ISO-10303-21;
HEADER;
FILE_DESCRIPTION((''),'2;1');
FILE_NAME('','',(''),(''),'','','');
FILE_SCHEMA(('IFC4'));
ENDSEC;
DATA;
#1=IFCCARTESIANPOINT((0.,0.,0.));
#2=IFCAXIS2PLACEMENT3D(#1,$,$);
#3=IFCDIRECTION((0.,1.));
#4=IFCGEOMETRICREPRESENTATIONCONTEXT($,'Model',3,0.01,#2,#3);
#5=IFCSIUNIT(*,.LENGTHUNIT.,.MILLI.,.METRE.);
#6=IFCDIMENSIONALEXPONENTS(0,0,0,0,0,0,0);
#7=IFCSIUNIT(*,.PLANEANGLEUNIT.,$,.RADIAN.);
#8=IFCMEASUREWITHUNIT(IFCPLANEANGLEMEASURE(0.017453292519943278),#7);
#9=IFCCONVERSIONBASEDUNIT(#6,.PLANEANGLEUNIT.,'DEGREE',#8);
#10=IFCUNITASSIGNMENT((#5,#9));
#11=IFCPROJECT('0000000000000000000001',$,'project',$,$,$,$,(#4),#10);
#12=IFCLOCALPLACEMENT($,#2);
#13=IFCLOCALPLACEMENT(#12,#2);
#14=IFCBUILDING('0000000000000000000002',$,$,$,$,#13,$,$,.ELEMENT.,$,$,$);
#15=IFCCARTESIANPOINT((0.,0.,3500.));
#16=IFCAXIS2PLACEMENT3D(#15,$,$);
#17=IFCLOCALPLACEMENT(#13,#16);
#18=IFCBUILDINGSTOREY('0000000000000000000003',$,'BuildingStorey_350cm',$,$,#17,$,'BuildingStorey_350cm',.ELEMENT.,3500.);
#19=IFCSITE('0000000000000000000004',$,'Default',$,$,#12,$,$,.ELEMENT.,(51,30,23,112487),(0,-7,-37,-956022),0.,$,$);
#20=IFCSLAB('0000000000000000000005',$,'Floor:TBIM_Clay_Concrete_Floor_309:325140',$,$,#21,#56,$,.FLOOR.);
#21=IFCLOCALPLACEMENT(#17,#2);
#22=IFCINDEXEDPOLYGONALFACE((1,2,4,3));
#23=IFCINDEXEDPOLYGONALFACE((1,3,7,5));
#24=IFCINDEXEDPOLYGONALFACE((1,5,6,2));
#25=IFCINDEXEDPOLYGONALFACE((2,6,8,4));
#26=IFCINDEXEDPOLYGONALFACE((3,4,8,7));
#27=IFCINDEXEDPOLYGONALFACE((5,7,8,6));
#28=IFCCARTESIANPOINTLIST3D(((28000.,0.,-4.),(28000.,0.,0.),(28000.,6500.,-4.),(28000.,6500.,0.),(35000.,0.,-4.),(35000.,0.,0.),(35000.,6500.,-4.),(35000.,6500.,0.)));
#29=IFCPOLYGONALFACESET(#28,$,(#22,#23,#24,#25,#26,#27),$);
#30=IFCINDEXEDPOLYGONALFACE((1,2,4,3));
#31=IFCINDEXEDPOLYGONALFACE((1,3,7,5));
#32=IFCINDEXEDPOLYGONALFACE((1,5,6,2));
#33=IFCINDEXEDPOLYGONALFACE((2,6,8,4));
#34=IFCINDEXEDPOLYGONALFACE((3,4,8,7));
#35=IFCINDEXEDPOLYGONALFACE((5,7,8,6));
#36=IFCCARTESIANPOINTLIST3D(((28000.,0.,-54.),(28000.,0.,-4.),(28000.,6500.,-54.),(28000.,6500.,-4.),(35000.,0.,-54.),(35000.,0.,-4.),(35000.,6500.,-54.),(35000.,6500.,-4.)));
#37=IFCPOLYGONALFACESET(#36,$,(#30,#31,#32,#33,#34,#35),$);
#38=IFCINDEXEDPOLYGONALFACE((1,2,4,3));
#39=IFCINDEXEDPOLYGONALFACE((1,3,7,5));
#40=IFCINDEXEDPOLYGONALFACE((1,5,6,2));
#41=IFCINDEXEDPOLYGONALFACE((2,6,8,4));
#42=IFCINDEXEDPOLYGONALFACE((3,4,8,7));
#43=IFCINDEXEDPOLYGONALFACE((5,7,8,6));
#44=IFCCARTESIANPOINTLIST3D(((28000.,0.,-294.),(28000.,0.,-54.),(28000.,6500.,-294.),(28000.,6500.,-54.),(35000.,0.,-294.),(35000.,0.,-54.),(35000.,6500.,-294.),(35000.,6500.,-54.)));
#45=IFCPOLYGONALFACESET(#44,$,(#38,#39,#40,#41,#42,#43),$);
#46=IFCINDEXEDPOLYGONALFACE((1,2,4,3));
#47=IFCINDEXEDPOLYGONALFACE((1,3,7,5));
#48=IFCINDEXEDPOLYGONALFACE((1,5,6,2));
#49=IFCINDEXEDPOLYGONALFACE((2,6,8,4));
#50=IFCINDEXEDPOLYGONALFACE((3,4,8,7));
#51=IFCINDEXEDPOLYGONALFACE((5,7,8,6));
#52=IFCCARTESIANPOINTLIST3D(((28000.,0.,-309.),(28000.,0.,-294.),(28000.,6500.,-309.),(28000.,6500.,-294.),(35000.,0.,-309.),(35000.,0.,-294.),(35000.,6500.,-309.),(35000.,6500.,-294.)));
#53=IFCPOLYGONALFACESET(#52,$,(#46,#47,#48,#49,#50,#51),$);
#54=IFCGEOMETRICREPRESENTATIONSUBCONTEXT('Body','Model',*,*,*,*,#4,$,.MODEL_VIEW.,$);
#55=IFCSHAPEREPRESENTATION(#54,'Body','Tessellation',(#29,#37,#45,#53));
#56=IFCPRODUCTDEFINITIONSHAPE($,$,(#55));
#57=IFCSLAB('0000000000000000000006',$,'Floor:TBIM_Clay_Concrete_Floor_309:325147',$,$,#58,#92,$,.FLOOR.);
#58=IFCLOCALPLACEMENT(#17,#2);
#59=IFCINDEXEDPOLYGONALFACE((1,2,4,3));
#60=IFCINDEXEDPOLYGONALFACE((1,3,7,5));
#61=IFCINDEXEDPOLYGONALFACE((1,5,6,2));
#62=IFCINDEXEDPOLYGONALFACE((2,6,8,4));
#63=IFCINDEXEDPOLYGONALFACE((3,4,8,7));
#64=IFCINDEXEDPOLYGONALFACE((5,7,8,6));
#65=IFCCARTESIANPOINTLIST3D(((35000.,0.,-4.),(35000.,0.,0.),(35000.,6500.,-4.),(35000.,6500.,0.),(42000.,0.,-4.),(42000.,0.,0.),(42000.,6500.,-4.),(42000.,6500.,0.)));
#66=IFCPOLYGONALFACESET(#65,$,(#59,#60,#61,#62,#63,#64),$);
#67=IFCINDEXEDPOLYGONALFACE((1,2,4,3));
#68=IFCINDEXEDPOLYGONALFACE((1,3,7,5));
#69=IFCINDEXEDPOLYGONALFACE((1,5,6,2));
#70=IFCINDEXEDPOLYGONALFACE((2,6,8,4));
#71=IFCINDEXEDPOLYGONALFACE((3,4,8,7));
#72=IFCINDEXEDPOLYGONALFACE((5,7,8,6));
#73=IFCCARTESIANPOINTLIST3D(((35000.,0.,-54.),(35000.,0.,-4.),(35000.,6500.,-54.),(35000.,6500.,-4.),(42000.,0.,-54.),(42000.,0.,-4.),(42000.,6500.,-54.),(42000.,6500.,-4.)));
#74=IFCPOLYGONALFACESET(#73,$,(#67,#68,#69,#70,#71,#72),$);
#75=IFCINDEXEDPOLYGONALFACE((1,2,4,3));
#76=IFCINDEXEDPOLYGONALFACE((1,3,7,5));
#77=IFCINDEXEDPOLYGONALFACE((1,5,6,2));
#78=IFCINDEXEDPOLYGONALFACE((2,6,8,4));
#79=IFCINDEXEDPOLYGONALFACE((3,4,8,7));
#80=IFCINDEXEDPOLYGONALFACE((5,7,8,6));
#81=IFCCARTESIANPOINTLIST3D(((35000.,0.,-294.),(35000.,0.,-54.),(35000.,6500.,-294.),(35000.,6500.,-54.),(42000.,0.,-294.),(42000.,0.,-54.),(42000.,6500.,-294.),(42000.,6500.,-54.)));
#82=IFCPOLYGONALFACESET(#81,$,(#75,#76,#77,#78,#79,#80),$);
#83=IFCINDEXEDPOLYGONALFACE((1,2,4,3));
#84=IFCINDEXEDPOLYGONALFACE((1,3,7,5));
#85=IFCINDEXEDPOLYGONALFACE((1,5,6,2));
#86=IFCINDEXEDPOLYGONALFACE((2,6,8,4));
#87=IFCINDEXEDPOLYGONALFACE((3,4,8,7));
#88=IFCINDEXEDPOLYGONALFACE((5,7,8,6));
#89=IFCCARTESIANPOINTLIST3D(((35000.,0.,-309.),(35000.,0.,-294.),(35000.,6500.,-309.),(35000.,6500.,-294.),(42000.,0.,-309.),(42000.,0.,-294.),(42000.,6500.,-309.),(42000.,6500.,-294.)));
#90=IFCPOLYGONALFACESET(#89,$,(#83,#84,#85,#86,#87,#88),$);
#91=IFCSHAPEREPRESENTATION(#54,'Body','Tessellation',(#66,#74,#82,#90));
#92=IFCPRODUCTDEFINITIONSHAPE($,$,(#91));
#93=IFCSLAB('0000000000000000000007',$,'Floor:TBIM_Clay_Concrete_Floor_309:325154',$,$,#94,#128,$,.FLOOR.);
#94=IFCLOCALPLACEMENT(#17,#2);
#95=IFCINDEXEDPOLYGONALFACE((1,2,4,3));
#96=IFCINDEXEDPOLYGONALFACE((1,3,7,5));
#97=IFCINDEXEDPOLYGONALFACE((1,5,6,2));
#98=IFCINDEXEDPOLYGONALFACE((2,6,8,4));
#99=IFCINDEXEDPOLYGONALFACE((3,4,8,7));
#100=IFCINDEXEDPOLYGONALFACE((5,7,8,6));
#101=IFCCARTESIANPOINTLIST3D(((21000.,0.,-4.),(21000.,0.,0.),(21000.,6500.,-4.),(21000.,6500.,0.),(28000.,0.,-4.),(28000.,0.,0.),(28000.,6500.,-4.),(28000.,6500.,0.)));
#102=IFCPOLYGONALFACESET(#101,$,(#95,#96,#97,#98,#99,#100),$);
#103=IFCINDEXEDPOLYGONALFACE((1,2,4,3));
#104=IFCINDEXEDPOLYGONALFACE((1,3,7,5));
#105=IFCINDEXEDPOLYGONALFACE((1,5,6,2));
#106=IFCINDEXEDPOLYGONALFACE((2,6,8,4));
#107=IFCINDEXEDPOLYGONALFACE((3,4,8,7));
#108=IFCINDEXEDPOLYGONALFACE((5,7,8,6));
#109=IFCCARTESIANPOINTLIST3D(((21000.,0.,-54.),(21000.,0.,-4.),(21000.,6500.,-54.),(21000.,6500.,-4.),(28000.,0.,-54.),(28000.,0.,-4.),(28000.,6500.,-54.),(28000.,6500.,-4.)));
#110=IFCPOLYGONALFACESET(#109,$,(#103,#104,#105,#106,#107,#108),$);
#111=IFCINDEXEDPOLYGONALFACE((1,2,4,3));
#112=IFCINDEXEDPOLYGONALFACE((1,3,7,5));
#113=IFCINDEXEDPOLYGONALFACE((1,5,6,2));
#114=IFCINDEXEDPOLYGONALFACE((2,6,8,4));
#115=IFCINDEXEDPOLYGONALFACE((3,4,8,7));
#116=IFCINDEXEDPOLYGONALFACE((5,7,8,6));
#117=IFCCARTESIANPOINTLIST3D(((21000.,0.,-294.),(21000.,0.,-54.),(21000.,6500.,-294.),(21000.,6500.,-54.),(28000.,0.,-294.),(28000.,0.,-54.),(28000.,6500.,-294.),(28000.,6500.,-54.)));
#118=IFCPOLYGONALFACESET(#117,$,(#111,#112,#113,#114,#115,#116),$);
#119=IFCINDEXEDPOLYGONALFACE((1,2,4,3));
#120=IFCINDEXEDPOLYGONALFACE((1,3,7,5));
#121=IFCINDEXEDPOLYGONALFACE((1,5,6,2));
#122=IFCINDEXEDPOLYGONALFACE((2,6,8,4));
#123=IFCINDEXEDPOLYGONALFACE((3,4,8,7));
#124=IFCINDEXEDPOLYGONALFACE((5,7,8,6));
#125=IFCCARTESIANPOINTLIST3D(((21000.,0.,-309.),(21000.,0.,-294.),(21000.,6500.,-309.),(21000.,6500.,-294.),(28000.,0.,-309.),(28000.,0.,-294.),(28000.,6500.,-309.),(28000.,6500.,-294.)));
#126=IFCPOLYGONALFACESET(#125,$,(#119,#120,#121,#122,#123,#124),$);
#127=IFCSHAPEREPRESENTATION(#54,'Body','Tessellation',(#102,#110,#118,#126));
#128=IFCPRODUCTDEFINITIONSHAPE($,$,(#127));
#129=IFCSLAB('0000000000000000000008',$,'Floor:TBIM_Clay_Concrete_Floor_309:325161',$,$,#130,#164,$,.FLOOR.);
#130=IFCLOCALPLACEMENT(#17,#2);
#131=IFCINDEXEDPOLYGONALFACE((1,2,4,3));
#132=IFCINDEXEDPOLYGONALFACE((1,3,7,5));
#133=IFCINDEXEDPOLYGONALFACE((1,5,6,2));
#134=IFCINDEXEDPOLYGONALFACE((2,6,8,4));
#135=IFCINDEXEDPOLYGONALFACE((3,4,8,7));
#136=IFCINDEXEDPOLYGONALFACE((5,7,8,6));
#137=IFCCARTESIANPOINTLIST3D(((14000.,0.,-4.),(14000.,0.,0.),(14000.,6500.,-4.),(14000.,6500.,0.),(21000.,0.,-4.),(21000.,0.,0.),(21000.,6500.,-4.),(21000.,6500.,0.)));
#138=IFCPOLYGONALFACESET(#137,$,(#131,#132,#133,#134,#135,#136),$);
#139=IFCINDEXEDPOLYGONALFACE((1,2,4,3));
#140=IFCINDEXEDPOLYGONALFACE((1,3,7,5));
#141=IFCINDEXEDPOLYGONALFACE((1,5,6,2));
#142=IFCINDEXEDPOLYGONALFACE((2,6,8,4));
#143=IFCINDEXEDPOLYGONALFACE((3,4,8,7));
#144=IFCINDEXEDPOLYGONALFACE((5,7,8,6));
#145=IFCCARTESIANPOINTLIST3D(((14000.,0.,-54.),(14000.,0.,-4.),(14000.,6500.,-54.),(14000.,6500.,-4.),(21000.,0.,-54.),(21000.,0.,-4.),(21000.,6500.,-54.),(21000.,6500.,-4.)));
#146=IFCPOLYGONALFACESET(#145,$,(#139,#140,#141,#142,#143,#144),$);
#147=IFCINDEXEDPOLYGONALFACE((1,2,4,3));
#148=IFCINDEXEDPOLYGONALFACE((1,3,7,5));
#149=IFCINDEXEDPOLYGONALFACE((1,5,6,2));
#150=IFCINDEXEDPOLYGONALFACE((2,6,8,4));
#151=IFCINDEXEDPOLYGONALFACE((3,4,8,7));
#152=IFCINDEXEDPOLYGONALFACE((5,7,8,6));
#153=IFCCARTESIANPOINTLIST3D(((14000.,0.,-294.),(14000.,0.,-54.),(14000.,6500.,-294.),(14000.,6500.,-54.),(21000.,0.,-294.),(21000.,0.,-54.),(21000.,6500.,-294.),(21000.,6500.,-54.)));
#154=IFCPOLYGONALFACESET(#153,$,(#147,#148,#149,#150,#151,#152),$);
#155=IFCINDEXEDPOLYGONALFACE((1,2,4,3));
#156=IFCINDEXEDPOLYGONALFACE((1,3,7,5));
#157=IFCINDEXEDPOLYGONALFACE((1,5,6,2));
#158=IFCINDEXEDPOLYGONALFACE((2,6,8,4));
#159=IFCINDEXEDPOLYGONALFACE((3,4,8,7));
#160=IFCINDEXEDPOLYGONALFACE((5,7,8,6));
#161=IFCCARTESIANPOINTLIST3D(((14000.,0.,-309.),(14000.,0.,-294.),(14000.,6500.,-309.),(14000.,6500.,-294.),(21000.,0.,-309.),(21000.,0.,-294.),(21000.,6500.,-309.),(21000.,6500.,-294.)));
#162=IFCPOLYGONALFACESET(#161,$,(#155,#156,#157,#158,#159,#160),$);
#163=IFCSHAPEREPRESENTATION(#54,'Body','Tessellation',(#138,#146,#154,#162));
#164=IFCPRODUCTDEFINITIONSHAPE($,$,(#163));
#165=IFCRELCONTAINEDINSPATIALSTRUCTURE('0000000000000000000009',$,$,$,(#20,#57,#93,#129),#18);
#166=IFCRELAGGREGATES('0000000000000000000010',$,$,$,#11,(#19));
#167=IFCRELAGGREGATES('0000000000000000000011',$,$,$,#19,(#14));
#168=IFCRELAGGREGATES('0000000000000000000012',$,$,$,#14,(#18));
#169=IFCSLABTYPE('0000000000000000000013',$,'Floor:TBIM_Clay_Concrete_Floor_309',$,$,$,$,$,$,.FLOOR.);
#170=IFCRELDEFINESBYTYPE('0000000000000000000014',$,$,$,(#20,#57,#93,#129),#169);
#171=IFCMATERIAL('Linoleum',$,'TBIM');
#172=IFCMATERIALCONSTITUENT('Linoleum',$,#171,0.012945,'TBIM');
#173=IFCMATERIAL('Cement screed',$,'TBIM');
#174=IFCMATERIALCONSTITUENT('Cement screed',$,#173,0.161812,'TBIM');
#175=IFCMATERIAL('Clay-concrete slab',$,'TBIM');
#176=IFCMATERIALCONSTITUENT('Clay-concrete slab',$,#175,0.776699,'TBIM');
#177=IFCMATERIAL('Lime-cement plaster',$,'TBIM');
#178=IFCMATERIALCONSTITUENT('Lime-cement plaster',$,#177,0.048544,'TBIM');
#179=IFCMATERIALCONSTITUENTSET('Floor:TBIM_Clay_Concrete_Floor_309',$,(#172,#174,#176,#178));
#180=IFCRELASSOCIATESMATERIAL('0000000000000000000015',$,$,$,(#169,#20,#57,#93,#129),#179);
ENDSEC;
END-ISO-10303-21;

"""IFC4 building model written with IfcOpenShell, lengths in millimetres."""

from ifc_helpers import new_model, entity, si_unit, converted_unit, direction, frame, origin, place, context, subcontext, project, spatial, indexed_curve, outline, extrude, material, constituent, constituent_set, type_object, element, save


model = new_model("IFC4")

# Units and contexts
model_context = context("Model", 3, precision=0.01, world=origin(), true_north=direction((0.0, 1.0)))
body_context = subcontext(model_context, "Body", "Model", "MODEL_VIEW")
ifc_project = project(units=[si_unit("LENGTHUNIT", "METRE", prefix="MILLI"), converted_unit("PLANEANGLEUNIT", "DEGREE", entity("IfcPlaneAngleMeasure", 0.017453292519943278), si_unit("PLANEANGLEUNIT", "RADIAN"), dimensions=[0, 0, 0, 0, 0, 0, 0])], contexts=[model_context])

# Site, building, storey
site_placement = place(None, origin())
site = spatial("IfcSite", under=ifc_project, at=site_placement, Name="Default", CompositionType="ELEMENT", RefLatitude=(51, 30, 23, 112487), RefLongitude=(0, -7, -37, -956022), RefElevation=0.0)
building_placement = place(site_placement, origin())
building = spatial("IfcBuilding", under=site, at=building_placement, CompositionType="ELEMENT")
storey_placement = place(building_placement, frame((0.0, 0.0, 3500.0)))
storey = spatial("IfcBuildingStorey", under=building, at=storey_placement, Name="BuildingStorey_350cm", LongName="BuildingStorey_350cm", CompositionType="ELEMENT", Elevation=3500.0)

# Slabs
ifc_material_1 = material(Name="Linoleum", Category="TBIM")
ifc_constituent_1 = constituent(ifc_material_1, Name="Linoleum", Category="TBIM", fraction=0.012945)
ifc_material_2 = material(Name="Cement screed", Category="TBIM")
ifc_constituent_2 = constituent(ifc_material_2, Name="Cement screed", Category="TBIM", fraction=0.161812)
ifc_material_3 = material(Name="Clay-concrete slab", Category="TBIM")
ifc_constituent_3 = constituent(ifc_material_3, Name="Clay-concrete slab", Category="TBIM", fraction=0.776699)
ifc_material_4 = material(Name="Lime-cement plaster", Category="TBIM")
ifc_constituent_4 = constituent(ifc_material_4, Name="Lime-cement plaster", Category="TBIM", fraction=0.048544)
ifc_constituent_set_1 = constituent_set(constituents=[ifc_constituent_1, ifc_constituent_2, ifc_constituent_3, ifc_constituent_4], Name="Floor:TBIM_Clay_Concrete_Floor_309")
slab_type = type_object("IfcSlabType", Name="Floor:TBIM_Clay_Concrete_Floor_309", PredefinedType="FLOOR", material=ifc_constituent_set_1)
slab_1_placement = place(storey_placement, origin())
element("IfcSlab", 1, at=slab_1_placement, inside=storey, type_object=slab_type, material=ifc_constituent_set_1, Name="Floor:TBIM_Clay_Concrete_Floor_309:325140", PredefinedType="FLOOR", context=body_context, shape_type="SweptSolid", body=[
    extrude(outline(indexed_curve([(-3500.0, -3250.0), (3500.0, -3250.0), (3500.0, 3250.0), (-3500.0, 3250.0), (-3500.0, -3250.0)], self_intersect=False)), frame((31500.0, 3250.0, -4.0), z_axis=(0.0, 0.0, 1.0), x_axis=(-1.0, 0.0, 0.0)), (0.0, 0.0, 1.0), 4.0),
    extrude(outline(indexed_curve([(-3500.0, -3250.0), (3500.0, -3250.0), (3500.0, 3250.0), (-3500.0, 3250.0), (-3500.0, -3250.0)], self_intersect=False)), frame((31500.0, 3250.0, -54.0), z_axis=(0.0, 0.0, 1.0), x_axis=(-1.0, 0.0, 0.0)), (0.0, 0.0, 1.0), 50.0),
    extrude(outline(indexed_curve([(-3500.0, -3250.0), (3500.0, -3250.0), (3500.0, 3250.0), (-3500.0, 3250.0), (-3500.0, -3250.0)], self_intersect=False)), frame((31500.0, 3250.0, -294.0), z_axis=(0.0, 0.0, 1.0), x_axis=(-1.0, 0.0, 0.0)), (0.0, 0.0, 1.0), 240.0),
    extrude(outline(indexed_curve([(-3500.0, -3250.0), (3500.0, -3250.0), (3500.0, 3250.0), (-3500.0, 3250.0), (-3500.0, -3250.0)], self_intersect=False)), frame((31500.0, 3250.0, -309.0), z_axis=(0.0, 0.0, 1.0), x_axis=(-1.0, 0.0, 0.0)), (0.0, 0.0, 1.0), 15.0),
])
slab_2_placement = place(storey_placement, origin())
element("IfcSlab", 2, at=slab_2_placement, inside=storey, type_object=slab_type, material=ifc_constituent_set_1, Name="Floor:TBIM_Clay_Concrete_Floor_309:325147", PredefinedType="FLOOR", context=body_context, shape_type="SweptSolid", body=[
    extrude(outline(indexed_curve([(-3500.0, -3250.0), (3500.0, -3250.0), (3500.0, 3250.0), (-3500.0, 3250.0), (-3500.0, -3250.0)], self_intersect=False)), frame((38500.0, 3250.0, -4.0), z_axis=(0.0, 0.0, 1.0), x_axis=(-1.0, 0.0, 0.0)), (0.0, 0.0, 1.0), 4.0),
    extrude(outline(indexed_curve([(-3500.0, -3250.0), (3500.0, -3250.0), (3500.0, 3250.0), (-3500.0, 3250.0), (-3500.0, -3250.0)], self_intersect=False)), frame((38500.0, 3250.0, -54.0), z_axis=(0.0, 0.0, 1.0), x_axis=(-1.0, 0.0, 0.0)), (0.0, 0.0, 1.0), 50.0),
    extrude(outline(indexed_curve([(-3500.0, -3250.0), (3500.0, -3250.0), (3500.0, 3250.0), (-3500.0, 3250.0), (-3500.0, -3250.0)], self_intersect=False)), frame((38500.0, 3250.0, -294.0), z_axis=(0.0, 0.0, 1.0), x_axis=(-1.0, 0.0, 0.0)), (0.0, 0.0, 1.0), 240.0),
    extrude(outline(indexed_curve([(-3500.0, -3250.0), (3500.0, -3250.0), (3500.0, 3250.0), (-3500.0, 3250.0), (-3500.0, -3250.0)], self_intersect=False)), frame((38500.0, 3250.0, -309.0), z_axis=(0.0, 0.0, 1.0), x_axis=(-1.0, 0.0, 0.0)), (0.0, 0.0, 1.0), 15.0),
])
slab_3_placement = place(storey_placement, origin())
element("IfcSlab", 3, at=slab_3_placement, inside=storey, type_object=slab_type, material=ifc_constituent_set_1, Name="Floor:TBIM_Clay_Concrete_Floor_309:325154", PredefinedType="FLOOR", context=body_context, shape_type="SweptSolid", body=[
    extrude(outline(indexed_curve([(-3500.0, -3250.0), (3500.0, -3250.0), (3500.0, 3250.0), (-3500.0, 3250.0), (-3500.0, -3250.0)], self_intersect=False)), frame((24500.0, 3250.0, -4.0), z_axis=(0.0, 0.0, 1.0), x_axis=(-1.0, 0.0, 0.0)), (0.0, 0.0, 1.0), 4.0),
    extrude(outline(indexed_curve([(-3500.0, -3250.0), (3500.0, -3250.0), (3500.0, 3250.0), (-3500.0, 3250.0), (-3500.0, -3250.0)], self_intersect=False)), frame((24500.0, 3250.0, -54.0), z_axis=(0.0, 0.0, 1.0), x_axis=(-1.0, 0.0, 0.0)), (0.0, 0.0, 1.0), 50.0),
    extrude(outline(indexed_curve([(-3500.0, -3250.0), (3500.0, -3250.0), (3500.0, 3250.0), (-3500.0, 3250.0), (-3500.0, -3250.0)], self_intersect=False)), frame((24500.0, 3250.0, -294.0), z_axis=(0.0, 0.0, 1.0), x_axis=(-1.0, 0.0, 0.0)), (0.0, 0.0, 1.0), 240.0),
    extrude(outline(indexed_curve([(-3500.0, -3250.0), (3500.0, -3250.0), (3500.0, 3250.0), (-3500.0, 3250.0), (-3500.0, -3250.0)], self_intersect=False)), frame((24500.0, 3250.0, -309.0), z_axis=(0.0, 0.0, 1.0), x_axis=(-1.0, 0.0, 0.0)), (0.0, 0.0, 1.0), 15.0),
])
slab_4_placement = place(storey_placement, origin())
element("IfcSlab", 4, at=slab_4_placement, inside=storey, type_object=slab_type, material=ifc_constituent_set_1, Name="Floor:TBIM_Clay_Concrete_Floor_309:325161", PredefinedType="FLOOR", context=body_context, shape_type="SweptSolid", body=[
    extrude(outline(indexed_curve([(-3500.0, -3250.0), (3500.0, -3250.0), (3500.0, 3250.0), (-3500.0, 3250.0), (-3500.0, -3250.0)], self_intersect=False)), frame((17500.0, 3250.0, -4.0), z_axis=(0.0, 0.0, 1.0), x_axis=(-1.0, 0.0, 0.0)), (0.0, 0.0, 1.0), 4.0),
    extrude(outline(indexed_curve([(-3500.0, -3250.0), (3500.0, -3250.0), (3500.0, 3250.0), (-3500.0, 3250.0), (-3500.0, -3250.0)], self_intersect=False)), frame((17500.0, 3250.0, -54.0), z_axis=(0.0, 0.0, 1.0), x_axis=(-1.0, 0.0, 0.0)), (0.0, 0.0, 1.0), 50.0),
    extrude(outline(indexed_curve([(-3500.0, -3250.0), (3500.0, -3250.0), (3500.0, 3250.0), (-3500.0, 3250.0), (-3500.0, -3250.0)], self_intersect=False)), frame((17500.0, 3250.0, -294.0), z_axis=(0.0, 0.0, 1.0), x_axis=(-1.0, 0.0, 0.0)), (0.0, 0.0, 1.0), 240.0),
    extrude(outline(indexed_curve([(-3500.0, -3250.0), (3500.0, -3250.0), (3500.0, 3250.0), (-3500.0, 3250.0), (-3500.0, -3250.0)], self_intersect=False)), frame((17500.0, 3250.0, -309.0), z_axis=(0.0, 0.0, 1.0), x_axis=(-1.0, 0.0, 0.0)), (0.0, 0.0, 1.0), 15.0),
])

save(model, "model.ifc")
